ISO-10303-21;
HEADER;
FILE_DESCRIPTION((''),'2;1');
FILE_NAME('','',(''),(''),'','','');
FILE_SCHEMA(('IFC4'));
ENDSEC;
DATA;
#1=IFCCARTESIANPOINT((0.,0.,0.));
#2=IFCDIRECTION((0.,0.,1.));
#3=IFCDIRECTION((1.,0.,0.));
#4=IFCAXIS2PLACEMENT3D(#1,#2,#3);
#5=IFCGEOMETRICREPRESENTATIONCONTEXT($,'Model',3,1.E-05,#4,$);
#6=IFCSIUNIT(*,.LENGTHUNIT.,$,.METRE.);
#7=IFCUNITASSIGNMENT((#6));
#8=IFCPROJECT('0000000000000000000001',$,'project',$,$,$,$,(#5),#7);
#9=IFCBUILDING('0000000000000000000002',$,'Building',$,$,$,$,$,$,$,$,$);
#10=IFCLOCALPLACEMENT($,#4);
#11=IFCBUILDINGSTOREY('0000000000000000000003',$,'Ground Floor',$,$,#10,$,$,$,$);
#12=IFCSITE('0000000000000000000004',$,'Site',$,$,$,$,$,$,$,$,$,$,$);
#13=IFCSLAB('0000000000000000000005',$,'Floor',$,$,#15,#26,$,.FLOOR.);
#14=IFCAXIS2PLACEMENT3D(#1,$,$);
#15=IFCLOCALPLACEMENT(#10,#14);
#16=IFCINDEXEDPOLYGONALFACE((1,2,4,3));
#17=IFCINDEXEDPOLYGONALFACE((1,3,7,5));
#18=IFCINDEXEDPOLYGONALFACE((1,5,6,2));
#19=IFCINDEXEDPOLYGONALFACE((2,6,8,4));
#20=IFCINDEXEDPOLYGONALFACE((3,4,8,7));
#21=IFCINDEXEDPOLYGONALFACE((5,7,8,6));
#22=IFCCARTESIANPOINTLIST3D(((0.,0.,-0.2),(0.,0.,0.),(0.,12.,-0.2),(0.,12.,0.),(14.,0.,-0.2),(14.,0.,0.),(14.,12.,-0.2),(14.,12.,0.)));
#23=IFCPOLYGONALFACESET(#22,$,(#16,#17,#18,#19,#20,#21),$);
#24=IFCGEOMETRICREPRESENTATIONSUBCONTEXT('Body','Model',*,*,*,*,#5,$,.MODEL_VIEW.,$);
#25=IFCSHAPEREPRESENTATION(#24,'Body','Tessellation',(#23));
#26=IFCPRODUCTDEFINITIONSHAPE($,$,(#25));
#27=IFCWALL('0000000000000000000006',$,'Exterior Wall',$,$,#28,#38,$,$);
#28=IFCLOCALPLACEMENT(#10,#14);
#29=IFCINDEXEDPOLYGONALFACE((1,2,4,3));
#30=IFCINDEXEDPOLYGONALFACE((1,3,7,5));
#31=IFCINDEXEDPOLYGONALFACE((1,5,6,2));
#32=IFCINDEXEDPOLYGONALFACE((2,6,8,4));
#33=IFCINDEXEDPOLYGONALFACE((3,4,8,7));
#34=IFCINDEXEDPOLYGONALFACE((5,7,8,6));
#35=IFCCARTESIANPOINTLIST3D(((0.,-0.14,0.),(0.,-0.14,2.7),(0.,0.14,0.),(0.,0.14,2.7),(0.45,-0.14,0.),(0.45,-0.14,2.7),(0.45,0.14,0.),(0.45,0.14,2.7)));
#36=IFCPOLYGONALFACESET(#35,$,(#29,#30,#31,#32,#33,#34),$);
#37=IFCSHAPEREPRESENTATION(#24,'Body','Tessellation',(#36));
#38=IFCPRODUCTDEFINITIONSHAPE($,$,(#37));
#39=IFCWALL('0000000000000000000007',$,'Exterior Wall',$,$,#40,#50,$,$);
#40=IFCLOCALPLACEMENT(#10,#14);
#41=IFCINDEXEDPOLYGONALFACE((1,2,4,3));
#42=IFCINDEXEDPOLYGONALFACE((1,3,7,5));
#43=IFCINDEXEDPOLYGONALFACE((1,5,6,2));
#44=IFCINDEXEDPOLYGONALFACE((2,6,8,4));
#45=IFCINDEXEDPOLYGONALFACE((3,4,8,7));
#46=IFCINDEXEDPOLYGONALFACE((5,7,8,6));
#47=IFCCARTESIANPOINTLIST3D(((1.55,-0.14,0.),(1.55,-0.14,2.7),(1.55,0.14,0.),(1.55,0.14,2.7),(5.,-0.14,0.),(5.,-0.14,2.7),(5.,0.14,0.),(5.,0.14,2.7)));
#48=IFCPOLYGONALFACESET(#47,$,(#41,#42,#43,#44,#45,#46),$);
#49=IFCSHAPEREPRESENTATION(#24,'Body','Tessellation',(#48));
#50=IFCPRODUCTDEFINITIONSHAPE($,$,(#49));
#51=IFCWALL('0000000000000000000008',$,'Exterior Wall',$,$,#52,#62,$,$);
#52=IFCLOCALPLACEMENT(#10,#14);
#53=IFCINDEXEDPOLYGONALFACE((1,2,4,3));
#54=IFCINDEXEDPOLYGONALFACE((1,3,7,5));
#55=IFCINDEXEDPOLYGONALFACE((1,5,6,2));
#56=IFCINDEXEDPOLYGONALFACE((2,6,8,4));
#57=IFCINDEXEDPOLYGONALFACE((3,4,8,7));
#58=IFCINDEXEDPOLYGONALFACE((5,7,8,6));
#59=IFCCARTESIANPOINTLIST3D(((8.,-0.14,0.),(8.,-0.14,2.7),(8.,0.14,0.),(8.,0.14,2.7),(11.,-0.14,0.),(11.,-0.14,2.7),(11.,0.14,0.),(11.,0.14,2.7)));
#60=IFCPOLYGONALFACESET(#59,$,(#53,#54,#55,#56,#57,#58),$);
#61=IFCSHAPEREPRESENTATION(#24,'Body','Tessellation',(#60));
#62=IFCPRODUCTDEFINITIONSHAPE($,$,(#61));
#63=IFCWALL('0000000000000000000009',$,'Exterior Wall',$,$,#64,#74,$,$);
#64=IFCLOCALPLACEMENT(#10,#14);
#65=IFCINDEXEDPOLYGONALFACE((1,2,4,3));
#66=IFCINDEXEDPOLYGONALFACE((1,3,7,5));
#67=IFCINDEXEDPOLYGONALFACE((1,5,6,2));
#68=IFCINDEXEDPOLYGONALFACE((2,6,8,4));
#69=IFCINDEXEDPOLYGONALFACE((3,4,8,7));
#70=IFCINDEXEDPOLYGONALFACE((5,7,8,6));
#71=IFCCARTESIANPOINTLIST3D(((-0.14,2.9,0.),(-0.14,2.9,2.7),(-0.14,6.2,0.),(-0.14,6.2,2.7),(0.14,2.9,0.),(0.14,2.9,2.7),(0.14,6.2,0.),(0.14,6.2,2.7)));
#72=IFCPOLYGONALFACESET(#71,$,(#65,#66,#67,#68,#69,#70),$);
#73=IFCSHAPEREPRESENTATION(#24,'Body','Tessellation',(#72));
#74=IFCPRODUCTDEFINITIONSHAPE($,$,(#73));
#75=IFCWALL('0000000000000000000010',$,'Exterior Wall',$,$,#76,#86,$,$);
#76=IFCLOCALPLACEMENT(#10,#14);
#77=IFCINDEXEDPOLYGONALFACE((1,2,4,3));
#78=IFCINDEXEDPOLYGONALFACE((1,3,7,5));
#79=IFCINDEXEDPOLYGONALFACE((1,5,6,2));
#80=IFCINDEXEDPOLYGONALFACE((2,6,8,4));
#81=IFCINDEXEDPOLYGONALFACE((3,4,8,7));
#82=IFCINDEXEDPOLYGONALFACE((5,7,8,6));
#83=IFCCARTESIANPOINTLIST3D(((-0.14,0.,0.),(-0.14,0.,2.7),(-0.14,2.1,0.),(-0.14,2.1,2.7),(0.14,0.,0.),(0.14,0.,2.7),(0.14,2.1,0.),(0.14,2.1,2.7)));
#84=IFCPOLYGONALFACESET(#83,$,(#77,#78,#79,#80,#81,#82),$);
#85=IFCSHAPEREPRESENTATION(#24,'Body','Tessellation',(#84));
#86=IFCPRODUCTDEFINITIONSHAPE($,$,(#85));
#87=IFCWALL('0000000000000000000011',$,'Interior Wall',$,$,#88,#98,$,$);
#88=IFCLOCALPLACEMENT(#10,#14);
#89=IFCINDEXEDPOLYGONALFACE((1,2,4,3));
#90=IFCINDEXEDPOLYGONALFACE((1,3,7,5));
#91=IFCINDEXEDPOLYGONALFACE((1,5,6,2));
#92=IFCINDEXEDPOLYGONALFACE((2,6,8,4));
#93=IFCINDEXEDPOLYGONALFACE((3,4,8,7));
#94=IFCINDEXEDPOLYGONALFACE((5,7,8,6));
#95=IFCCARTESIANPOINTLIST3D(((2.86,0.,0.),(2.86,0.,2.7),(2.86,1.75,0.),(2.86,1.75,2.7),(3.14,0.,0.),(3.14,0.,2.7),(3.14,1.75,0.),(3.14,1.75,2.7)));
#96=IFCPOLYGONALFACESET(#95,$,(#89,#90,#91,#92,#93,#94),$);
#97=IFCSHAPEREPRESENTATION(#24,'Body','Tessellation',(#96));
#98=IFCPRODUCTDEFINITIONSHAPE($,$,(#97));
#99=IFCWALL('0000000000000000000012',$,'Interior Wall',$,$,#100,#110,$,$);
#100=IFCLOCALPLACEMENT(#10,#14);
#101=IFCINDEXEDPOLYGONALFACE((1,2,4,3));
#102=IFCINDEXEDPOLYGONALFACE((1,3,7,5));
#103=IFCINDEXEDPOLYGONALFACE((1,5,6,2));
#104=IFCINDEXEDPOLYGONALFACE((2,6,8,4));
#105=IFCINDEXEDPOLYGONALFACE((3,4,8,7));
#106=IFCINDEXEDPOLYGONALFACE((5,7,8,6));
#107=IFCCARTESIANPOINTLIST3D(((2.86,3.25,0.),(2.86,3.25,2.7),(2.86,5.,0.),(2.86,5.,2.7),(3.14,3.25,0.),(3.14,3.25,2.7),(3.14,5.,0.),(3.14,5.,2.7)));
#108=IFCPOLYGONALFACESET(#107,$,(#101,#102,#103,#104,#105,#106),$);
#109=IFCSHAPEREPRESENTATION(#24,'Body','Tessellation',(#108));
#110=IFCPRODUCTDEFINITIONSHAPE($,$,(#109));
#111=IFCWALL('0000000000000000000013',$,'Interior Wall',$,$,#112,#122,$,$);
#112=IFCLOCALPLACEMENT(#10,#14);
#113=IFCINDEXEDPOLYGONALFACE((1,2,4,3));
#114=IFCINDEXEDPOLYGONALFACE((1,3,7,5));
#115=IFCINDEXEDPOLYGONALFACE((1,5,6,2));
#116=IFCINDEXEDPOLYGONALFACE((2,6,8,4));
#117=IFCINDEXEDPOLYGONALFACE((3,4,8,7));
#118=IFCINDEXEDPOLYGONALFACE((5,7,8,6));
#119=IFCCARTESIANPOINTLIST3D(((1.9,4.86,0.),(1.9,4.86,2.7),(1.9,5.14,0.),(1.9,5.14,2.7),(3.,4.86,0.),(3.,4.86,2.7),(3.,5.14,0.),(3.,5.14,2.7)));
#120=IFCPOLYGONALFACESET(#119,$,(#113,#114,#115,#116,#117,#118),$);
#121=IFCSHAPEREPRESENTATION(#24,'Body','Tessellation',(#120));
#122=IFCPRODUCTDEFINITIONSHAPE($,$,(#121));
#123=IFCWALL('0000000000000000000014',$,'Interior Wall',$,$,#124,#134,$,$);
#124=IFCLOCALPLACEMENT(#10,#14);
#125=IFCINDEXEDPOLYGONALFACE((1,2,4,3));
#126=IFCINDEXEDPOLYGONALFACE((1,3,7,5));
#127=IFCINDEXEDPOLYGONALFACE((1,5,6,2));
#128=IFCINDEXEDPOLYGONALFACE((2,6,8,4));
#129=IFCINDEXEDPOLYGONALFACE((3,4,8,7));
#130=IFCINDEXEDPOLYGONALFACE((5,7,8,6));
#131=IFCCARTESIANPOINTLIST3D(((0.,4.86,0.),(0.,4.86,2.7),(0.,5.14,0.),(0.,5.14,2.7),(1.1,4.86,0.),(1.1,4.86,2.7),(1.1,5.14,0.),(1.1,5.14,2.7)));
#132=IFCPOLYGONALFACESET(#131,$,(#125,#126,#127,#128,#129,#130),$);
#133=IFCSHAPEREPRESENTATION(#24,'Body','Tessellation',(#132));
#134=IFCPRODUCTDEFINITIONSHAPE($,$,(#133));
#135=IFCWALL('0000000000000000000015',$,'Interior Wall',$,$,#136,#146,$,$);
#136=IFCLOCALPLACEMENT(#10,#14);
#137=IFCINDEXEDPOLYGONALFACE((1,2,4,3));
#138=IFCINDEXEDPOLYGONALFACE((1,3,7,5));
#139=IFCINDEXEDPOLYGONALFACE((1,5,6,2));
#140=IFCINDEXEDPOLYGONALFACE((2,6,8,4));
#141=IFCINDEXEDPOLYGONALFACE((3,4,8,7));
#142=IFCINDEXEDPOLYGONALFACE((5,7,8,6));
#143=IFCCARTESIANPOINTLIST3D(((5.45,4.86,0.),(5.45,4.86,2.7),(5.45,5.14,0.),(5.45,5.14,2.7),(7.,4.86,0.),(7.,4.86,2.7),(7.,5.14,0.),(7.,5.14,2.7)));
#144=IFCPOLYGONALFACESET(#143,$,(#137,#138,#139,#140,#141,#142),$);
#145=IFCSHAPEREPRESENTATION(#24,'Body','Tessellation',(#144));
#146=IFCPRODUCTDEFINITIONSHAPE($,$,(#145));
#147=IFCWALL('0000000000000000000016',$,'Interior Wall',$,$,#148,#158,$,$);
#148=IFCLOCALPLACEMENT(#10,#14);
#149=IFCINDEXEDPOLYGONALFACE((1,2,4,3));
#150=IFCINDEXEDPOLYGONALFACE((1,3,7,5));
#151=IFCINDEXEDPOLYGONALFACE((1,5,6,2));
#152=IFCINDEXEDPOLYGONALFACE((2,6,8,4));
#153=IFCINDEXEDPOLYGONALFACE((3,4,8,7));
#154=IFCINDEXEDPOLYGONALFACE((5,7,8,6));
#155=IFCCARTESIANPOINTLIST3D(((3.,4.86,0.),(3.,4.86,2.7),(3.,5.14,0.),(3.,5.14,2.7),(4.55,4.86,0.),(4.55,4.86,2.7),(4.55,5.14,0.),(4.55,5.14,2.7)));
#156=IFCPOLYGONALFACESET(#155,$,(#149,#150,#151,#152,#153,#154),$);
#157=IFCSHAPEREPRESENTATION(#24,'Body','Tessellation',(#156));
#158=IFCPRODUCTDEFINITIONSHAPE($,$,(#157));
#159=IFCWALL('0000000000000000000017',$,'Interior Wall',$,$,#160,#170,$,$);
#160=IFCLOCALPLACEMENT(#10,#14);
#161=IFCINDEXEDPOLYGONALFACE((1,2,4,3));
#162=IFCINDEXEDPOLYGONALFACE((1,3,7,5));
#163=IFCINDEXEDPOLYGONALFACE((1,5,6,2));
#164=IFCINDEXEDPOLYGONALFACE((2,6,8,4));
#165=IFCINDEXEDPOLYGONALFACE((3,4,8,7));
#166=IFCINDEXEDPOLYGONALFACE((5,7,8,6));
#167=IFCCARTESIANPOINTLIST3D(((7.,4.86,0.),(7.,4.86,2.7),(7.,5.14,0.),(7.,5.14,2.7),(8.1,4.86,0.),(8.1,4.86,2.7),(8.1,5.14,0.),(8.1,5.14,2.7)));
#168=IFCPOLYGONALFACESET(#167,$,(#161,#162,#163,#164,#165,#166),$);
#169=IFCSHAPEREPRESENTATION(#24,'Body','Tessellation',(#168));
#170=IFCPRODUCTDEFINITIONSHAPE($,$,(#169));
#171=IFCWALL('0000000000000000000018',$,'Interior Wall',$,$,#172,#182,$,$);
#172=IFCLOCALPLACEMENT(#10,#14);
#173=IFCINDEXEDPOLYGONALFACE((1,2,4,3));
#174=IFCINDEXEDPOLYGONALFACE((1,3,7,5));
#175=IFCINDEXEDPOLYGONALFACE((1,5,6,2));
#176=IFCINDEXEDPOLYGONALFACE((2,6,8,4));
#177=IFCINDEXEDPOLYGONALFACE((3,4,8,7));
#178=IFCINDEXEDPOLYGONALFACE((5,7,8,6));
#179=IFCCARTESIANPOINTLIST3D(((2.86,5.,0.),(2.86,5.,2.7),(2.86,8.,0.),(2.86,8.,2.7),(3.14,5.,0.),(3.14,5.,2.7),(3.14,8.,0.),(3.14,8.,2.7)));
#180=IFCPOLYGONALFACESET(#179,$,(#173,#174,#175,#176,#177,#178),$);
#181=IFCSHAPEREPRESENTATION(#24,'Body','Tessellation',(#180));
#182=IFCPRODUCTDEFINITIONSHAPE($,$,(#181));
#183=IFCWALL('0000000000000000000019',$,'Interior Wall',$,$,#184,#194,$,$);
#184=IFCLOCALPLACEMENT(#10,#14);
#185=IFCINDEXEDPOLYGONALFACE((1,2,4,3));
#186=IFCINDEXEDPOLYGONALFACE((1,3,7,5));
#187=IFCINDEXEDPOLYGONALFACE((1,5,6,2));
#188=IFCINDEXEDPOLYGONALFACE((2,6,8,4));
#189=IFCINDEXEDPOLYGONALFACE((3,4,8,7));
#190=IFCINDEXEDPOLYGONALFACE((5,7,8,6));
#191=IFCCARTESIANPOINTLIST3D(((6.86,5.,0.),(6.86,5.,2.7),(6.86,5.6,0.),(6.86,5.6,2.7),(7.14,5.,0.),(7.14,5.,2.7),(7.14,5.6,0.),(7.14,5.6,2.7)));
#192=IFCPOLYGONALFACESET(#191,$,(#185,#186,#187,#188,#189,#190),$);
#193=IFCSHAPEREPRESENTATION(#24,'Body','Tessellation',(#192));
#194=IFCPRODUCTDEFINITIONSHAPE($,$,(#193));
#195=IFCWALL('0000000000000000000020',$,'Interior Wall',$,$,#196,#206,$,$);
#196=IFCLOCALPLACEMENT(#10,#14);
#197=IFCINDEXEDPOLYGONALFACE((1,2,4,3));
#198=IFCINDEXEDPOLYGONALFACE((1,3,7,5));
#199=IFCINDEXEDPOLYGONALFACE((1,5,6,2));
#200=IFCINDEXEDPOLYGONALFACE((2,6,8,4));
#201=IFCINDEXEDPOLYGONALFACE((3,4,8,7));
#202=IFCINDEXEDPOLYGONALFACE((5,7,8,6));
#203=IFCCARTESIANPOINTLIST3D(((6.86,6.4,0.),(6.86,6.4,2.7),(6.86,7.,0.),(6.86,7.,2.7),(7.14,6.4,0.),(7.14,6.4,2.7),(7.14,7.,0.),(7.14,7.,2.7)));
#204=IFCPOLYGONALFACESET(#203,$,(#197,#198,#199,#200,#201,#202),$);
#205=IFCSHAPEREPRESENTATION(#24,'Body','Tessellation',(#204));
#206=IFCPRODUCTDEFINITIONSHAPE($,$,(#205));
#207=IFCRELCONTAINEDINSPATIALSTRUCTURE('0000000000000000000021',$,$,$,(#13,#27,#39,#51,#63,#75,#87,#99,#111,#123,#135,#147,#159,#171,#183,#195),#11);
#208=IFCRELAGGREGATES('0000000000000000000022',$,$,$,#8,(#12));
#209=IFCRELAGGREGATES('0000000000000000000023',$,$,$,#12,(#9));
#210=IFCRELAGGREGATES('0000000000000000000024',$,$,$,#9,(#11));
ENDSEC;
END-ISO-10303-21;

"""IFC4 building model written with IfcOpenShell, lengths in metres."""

from ifc_helpers import new_model, si_unit, frame, origin_with_axes, place, context, subcontext, project, spatial, indexed_curve, outline, extrude, element, save


model = new_model("IFC4")

# Units and contexts
model_context = context("Model", 3, precision=1e-05, world=origin_with_axes())
body_context = subcontext(model_context, "Body", "Model", "MODEL_VIEW")
ifc_project = project(units=[si_unit("LENGTHUNIT", "METRE")], contexts=[model_context])

# Site, building, storey
site = spatial("IfcSite", under=ifc_project, Name="Site")
building = spatial("IfcBuilding", under=site, Name="Building")
storey_placement = place(None, origin_with_axes())
storey = spatial("IfcBuildingStorey", under=building, at=storey_placement, Name="Ground Floor")

# Slab
slab_placement = place(storey_placement, frame((0.0, 0.0, -0.2), z_axis=(0.0, 0.0, 1.0), x_axis=(1.0, 0.0, 0.0)))
element("IfcSlab", 1, at=slab_placement, inside=storey, Name="Floor", PredefinedType="FLOOR", context=body_context, shape_type="SweptSolid", body=[
    extrude(outline(indexed_curve([(0.0, 0.0), (14.0, 0.0), (14.0, 12.0), (0.0, 12.0)])), None, (0.0, 0.0, 1.0), 0.2),
])

# Walls
wall_1_placement = place(storey_placement, origin_with_axes())
element("IfcWall", 2, at=wall_1_placement, inside=storey, Name="Exterior Wall", context=body_context, shape_type="SweptSolid", body=[
    extrude(outline(indexed_curve([(0.0, 0.0), (0.0, 0.28), (0.45, 0.28), (0.45, 0.0), (0.0, 0.0)], self_intersect=False)), frame((0.0, -0.14, 0.0), z_axis=(0.0, 0.0, 1.0), x_axis=(1.0, 0.0, 0.0)), (0.0, 0.0, 1.0), 2.7),
])
wall_2_placement = place(storey_placement, frame((1.55, 0.0, 0.0), z_axis=(0.0, 0.0, 1.0), x_axis=(1.0, 0.0, 0.0)))
element("IfcWall", 3, at=wall_2_placement, inside=storey, Name="Exterior Wall", context=body_context, shape_type="SweptSolid", body=[
    extrude(outline(indexed_curve([(0.0, 0.0), (0.0, 0.28), (3.45, 0.28), (3.45, 0.0), (0.0, 0.0)], self_intersect=False)), frame((0.0, -0.14, 0.0), z_axis=(0.0, 0.0, 1.0), x_axis=(1.0, 0.0, 0.0)), (0.0, 0.0, 1.0), 2.7),
])
wall_3_placement = place(storey_placement, frame((8.0, 0.0, 0.0), z_axis=(0.0, 0.0, 1.0), x_axis=(1.0, 0.0, 0.0)))
element("IfcWall", 4, at=wall_3_placement, inside=storey, Name="Exterior Wall", context=body_context, shape_type="SweptSolid", body=[
    extrude(outline(indexed_curve([(0.0, 0.0), (0.0, 0.28), (3.0, 0.28), (3.0, 0.0), (0.0, 0.0)], self_intersect=False)), frame((0.0, -0.14, 0.0), z_axis=(0.0, 0.0, 1.0), x_axis=(1.0, 0.0, 0.0)), (0.0, 0.0, 1.0), 2.7),
])
wall_4_placement = place(storey_placement, frame((0.0, 6.2, 0.0), z_axis=(0.0, 0.0, 1.0), x_axis=(0.0, -1.0, 0.0)))
element("IfcWall", 5, at=wall_4_placement, inside=storey, Name="Exterior Wall", context=body_context, shape_type="SweptSolid", body=[
    extrude(outline(indexed_curve([(0.0, 0.0), (0.0, 0.28), (3.3, 0.28), (3.3, 0.0), (0.0, 0.0)], self_intersect=False)), frame((0.0, -0.14, 0.0), z_axis=(0.0, 0.0, 1.0), x_axis=(1.0, 0.0, 0.0)), (0.0, 0.0, 1.0), 2.7),
])
wall_5_placement = place(storey_placement, frame((0.0, 2.1, 0.0), z_axis=(0.0, 0.0, 1.0), x_axis=(0.0, -1.0, 0.0)))
element("IfcWall", 6, at=wall_5_placement, inside=storey, Name="Exterior Wall", context=body_context, shape_type="SweptSolid", body=[
    extrude(outline(indexed_curve([(0.0, 0.0), (0.0, 0.28), (2.1, 0.28), (2.1, 0.0), (0.0, 0.0)], self_intersect=False)), frame((0.0, -0.14, 0.0), z_axis=(0.0, 0.0, 1.0), x_axis=(1.0, 0.0, 0.0)), (0.0, 0.0, 1.0), 2.7),
])
for number, where, z_axis, x_axis, name in (
    (7, (3.0, 0.0, 0.0), (0.0, 0.0, 1.0), (0.0, 1.0, 0.0), "Interior Wall"),
    (8, (3.0, 3.25, 0.0), (0.0, 0.0, 1.0), (0.0, 1.0, 0.0), "Interior Wall"),
):
    element("IfcWall", number, at=place(storey_placement, frame(where, z_axis=z_axis, x_axis=x_axis)), inside=storey, Name=name, context=body_context, shape_type="SweptSolid", body=[
        extrude(outline(indexed_curve([(0.0, 0.0), (0.0, 0.28), (1.75, 0.28), (1.75, 0.0), (0.0, 0.0)], self_intersect=False)), frame((0.0, -0.14, 0.0), z_axis=(0.0, 0.0, 1.0), x_axis=(1.0, 0.0, 0.0)), (0.0, 0.0, 1.0), 2.7),
    ])
for number, where, z_axis, x_axis, name in (
    (9, (3.0, 5.0, 0.0), (0.0, 0.0, 1.0), (-1.0, 0.0, 0.0), "Interior Wall"),
    (10, (1.1, 5.0, 0.0), (0.0, 0.0, 1.0), (-1.0, 0.0, 0.0), "Interior Wall"),
):
    element("IfcWall", number, at=place(storey_placement, frame(where, z_axis=z_axis, x_axis=x_axis)), inside=storey, Name=name, context=body_context, shape_type="SweptSolid", body=[
        extrude(outline(indexed_curve([(0.0, 0.0), (0.0, 0.28), (1.1, 0.28), (1.1, 0.0), (0.0, 0.0)], self_intersect=False)), frame((0.0, -0.14, 0.0), z_axis=(0.0, 0.0, 1.0), x_axis=(1.0, 0.0, 0.0)), (0.0, 0.0, 1.0), 2.7),
    ])
for number, where, z_axis, x_axis, name in (
    (11, (7.0, 5.0, 0.0), (0.0, 0.0, 1.0), (-1.0, 0.0, 0.0), "Interior Wall"),
    (12, (4.55, 5.0, 0.0), (0.0, 0.0, 1.0), (-1.0, 0.0, 0.0), "Interior Wall"),
):
    element("IfcWall", number, at=place(storey_placement, frame(where, z_axis=z_axis, x_axis=x_axis)), inside=storey, Name=name, context=body_context, shape_type="SweptSolid", body=[
        extrude(outline(indexed_curve([(0.0, 0.0), (0.0, 0.28), (1.55, 0.28), (1.55, 0.0), (0.0, 0.0)], self_intersect=False)), frame((0.0, -0.14, 0.0), z_axis=(0.0, 0.0, 1.0), x_axis=(1.0, 0.0, 0.0)), (0.0, 0.0, 1.0), 2.7),
    ])
wall_6_placement = place(storey_placement, frame((8.1, 5.0, 0.0), z_axis=(0.0, 0.0, 1.0), x_axis=(-1.0, 0.0, 0.0)))
element("IfcWall", 13, at=wall_6_placement, inside=storey, Name="Interior Wall", context=body_context, shape_type="SweptSolid", body=[
    extrude(outline(indexed_curve([(0.0, 0.0), (0.0, 0.28), (1.1, 0.28), (1.1, 0.0), (0.0, 0.0)], self_intersect=False)), frame((0.0, -0.14, 0.0), z_axis=(0.0, 0.0, 1.0), x_axis=(1.0, 0.0, 0.0)), (0.0, 0.0, 1.0), 2.7),
])
wall_7_placement = place(storey_placement, frame((3.0, 5.0, 0.0), z_axis=(0.0, 0.0, 1.0), x_axis=(0.0, 1.0, 0.0)))
element("IfcWall", 14, at=wall_7_placement, inside=storey, Name="Interior Wall", context=body_context, shape_type="SweptSolid", body=[
    extrude(outline(indexed_curve([(0.0, 0.0), (0.0, 0.28), (3.0, 0.28), (3.0, 0.0), (0.0, 0.0)], self_intersect=False)), frame((0.0, -0.14, 0.0), z_axis=(0.0, 0.0, 1.0), x_axis=(1.0, 0.0, 0.0)), (0.0, 0.0, 1.0), 2.7),
])
for number, where, z_axis, x_axis, name in (
    (15, (7.0, 5.0, 0.0), (0.0, 0.0, 1.0), (0.0, 1.0, 0.0), "Interior Wall"),
    (16, (7.0, 6.4, 0.0), (0.0, 0.0, 1.0), (0.0, 1.0, 0.0), "Interior Wall"),
):
    element("IfcWall", number, at=place(storey_placement, frame(where, z_axis=z_axis, x_axis=x_axis)), inside=storey, Name=name, context=body_context, shape_type="SweptSolid", body=[
        extrude(outline(indexed_curve([(0.0, 0.0), (0.0, 0.28), (0.6, 0.28), (0.6, 0.0), (0.0, 0.0)], self_intersect=False)), frame((0.0, -0.14, 0.0), z_axis=(0.0, 0.0, 1.0), x_axis=(1.0, 0.0, 0.0)), (0.0, 0.0, 1.0), 2.7),
    ])

save(model, "model.ifc")
